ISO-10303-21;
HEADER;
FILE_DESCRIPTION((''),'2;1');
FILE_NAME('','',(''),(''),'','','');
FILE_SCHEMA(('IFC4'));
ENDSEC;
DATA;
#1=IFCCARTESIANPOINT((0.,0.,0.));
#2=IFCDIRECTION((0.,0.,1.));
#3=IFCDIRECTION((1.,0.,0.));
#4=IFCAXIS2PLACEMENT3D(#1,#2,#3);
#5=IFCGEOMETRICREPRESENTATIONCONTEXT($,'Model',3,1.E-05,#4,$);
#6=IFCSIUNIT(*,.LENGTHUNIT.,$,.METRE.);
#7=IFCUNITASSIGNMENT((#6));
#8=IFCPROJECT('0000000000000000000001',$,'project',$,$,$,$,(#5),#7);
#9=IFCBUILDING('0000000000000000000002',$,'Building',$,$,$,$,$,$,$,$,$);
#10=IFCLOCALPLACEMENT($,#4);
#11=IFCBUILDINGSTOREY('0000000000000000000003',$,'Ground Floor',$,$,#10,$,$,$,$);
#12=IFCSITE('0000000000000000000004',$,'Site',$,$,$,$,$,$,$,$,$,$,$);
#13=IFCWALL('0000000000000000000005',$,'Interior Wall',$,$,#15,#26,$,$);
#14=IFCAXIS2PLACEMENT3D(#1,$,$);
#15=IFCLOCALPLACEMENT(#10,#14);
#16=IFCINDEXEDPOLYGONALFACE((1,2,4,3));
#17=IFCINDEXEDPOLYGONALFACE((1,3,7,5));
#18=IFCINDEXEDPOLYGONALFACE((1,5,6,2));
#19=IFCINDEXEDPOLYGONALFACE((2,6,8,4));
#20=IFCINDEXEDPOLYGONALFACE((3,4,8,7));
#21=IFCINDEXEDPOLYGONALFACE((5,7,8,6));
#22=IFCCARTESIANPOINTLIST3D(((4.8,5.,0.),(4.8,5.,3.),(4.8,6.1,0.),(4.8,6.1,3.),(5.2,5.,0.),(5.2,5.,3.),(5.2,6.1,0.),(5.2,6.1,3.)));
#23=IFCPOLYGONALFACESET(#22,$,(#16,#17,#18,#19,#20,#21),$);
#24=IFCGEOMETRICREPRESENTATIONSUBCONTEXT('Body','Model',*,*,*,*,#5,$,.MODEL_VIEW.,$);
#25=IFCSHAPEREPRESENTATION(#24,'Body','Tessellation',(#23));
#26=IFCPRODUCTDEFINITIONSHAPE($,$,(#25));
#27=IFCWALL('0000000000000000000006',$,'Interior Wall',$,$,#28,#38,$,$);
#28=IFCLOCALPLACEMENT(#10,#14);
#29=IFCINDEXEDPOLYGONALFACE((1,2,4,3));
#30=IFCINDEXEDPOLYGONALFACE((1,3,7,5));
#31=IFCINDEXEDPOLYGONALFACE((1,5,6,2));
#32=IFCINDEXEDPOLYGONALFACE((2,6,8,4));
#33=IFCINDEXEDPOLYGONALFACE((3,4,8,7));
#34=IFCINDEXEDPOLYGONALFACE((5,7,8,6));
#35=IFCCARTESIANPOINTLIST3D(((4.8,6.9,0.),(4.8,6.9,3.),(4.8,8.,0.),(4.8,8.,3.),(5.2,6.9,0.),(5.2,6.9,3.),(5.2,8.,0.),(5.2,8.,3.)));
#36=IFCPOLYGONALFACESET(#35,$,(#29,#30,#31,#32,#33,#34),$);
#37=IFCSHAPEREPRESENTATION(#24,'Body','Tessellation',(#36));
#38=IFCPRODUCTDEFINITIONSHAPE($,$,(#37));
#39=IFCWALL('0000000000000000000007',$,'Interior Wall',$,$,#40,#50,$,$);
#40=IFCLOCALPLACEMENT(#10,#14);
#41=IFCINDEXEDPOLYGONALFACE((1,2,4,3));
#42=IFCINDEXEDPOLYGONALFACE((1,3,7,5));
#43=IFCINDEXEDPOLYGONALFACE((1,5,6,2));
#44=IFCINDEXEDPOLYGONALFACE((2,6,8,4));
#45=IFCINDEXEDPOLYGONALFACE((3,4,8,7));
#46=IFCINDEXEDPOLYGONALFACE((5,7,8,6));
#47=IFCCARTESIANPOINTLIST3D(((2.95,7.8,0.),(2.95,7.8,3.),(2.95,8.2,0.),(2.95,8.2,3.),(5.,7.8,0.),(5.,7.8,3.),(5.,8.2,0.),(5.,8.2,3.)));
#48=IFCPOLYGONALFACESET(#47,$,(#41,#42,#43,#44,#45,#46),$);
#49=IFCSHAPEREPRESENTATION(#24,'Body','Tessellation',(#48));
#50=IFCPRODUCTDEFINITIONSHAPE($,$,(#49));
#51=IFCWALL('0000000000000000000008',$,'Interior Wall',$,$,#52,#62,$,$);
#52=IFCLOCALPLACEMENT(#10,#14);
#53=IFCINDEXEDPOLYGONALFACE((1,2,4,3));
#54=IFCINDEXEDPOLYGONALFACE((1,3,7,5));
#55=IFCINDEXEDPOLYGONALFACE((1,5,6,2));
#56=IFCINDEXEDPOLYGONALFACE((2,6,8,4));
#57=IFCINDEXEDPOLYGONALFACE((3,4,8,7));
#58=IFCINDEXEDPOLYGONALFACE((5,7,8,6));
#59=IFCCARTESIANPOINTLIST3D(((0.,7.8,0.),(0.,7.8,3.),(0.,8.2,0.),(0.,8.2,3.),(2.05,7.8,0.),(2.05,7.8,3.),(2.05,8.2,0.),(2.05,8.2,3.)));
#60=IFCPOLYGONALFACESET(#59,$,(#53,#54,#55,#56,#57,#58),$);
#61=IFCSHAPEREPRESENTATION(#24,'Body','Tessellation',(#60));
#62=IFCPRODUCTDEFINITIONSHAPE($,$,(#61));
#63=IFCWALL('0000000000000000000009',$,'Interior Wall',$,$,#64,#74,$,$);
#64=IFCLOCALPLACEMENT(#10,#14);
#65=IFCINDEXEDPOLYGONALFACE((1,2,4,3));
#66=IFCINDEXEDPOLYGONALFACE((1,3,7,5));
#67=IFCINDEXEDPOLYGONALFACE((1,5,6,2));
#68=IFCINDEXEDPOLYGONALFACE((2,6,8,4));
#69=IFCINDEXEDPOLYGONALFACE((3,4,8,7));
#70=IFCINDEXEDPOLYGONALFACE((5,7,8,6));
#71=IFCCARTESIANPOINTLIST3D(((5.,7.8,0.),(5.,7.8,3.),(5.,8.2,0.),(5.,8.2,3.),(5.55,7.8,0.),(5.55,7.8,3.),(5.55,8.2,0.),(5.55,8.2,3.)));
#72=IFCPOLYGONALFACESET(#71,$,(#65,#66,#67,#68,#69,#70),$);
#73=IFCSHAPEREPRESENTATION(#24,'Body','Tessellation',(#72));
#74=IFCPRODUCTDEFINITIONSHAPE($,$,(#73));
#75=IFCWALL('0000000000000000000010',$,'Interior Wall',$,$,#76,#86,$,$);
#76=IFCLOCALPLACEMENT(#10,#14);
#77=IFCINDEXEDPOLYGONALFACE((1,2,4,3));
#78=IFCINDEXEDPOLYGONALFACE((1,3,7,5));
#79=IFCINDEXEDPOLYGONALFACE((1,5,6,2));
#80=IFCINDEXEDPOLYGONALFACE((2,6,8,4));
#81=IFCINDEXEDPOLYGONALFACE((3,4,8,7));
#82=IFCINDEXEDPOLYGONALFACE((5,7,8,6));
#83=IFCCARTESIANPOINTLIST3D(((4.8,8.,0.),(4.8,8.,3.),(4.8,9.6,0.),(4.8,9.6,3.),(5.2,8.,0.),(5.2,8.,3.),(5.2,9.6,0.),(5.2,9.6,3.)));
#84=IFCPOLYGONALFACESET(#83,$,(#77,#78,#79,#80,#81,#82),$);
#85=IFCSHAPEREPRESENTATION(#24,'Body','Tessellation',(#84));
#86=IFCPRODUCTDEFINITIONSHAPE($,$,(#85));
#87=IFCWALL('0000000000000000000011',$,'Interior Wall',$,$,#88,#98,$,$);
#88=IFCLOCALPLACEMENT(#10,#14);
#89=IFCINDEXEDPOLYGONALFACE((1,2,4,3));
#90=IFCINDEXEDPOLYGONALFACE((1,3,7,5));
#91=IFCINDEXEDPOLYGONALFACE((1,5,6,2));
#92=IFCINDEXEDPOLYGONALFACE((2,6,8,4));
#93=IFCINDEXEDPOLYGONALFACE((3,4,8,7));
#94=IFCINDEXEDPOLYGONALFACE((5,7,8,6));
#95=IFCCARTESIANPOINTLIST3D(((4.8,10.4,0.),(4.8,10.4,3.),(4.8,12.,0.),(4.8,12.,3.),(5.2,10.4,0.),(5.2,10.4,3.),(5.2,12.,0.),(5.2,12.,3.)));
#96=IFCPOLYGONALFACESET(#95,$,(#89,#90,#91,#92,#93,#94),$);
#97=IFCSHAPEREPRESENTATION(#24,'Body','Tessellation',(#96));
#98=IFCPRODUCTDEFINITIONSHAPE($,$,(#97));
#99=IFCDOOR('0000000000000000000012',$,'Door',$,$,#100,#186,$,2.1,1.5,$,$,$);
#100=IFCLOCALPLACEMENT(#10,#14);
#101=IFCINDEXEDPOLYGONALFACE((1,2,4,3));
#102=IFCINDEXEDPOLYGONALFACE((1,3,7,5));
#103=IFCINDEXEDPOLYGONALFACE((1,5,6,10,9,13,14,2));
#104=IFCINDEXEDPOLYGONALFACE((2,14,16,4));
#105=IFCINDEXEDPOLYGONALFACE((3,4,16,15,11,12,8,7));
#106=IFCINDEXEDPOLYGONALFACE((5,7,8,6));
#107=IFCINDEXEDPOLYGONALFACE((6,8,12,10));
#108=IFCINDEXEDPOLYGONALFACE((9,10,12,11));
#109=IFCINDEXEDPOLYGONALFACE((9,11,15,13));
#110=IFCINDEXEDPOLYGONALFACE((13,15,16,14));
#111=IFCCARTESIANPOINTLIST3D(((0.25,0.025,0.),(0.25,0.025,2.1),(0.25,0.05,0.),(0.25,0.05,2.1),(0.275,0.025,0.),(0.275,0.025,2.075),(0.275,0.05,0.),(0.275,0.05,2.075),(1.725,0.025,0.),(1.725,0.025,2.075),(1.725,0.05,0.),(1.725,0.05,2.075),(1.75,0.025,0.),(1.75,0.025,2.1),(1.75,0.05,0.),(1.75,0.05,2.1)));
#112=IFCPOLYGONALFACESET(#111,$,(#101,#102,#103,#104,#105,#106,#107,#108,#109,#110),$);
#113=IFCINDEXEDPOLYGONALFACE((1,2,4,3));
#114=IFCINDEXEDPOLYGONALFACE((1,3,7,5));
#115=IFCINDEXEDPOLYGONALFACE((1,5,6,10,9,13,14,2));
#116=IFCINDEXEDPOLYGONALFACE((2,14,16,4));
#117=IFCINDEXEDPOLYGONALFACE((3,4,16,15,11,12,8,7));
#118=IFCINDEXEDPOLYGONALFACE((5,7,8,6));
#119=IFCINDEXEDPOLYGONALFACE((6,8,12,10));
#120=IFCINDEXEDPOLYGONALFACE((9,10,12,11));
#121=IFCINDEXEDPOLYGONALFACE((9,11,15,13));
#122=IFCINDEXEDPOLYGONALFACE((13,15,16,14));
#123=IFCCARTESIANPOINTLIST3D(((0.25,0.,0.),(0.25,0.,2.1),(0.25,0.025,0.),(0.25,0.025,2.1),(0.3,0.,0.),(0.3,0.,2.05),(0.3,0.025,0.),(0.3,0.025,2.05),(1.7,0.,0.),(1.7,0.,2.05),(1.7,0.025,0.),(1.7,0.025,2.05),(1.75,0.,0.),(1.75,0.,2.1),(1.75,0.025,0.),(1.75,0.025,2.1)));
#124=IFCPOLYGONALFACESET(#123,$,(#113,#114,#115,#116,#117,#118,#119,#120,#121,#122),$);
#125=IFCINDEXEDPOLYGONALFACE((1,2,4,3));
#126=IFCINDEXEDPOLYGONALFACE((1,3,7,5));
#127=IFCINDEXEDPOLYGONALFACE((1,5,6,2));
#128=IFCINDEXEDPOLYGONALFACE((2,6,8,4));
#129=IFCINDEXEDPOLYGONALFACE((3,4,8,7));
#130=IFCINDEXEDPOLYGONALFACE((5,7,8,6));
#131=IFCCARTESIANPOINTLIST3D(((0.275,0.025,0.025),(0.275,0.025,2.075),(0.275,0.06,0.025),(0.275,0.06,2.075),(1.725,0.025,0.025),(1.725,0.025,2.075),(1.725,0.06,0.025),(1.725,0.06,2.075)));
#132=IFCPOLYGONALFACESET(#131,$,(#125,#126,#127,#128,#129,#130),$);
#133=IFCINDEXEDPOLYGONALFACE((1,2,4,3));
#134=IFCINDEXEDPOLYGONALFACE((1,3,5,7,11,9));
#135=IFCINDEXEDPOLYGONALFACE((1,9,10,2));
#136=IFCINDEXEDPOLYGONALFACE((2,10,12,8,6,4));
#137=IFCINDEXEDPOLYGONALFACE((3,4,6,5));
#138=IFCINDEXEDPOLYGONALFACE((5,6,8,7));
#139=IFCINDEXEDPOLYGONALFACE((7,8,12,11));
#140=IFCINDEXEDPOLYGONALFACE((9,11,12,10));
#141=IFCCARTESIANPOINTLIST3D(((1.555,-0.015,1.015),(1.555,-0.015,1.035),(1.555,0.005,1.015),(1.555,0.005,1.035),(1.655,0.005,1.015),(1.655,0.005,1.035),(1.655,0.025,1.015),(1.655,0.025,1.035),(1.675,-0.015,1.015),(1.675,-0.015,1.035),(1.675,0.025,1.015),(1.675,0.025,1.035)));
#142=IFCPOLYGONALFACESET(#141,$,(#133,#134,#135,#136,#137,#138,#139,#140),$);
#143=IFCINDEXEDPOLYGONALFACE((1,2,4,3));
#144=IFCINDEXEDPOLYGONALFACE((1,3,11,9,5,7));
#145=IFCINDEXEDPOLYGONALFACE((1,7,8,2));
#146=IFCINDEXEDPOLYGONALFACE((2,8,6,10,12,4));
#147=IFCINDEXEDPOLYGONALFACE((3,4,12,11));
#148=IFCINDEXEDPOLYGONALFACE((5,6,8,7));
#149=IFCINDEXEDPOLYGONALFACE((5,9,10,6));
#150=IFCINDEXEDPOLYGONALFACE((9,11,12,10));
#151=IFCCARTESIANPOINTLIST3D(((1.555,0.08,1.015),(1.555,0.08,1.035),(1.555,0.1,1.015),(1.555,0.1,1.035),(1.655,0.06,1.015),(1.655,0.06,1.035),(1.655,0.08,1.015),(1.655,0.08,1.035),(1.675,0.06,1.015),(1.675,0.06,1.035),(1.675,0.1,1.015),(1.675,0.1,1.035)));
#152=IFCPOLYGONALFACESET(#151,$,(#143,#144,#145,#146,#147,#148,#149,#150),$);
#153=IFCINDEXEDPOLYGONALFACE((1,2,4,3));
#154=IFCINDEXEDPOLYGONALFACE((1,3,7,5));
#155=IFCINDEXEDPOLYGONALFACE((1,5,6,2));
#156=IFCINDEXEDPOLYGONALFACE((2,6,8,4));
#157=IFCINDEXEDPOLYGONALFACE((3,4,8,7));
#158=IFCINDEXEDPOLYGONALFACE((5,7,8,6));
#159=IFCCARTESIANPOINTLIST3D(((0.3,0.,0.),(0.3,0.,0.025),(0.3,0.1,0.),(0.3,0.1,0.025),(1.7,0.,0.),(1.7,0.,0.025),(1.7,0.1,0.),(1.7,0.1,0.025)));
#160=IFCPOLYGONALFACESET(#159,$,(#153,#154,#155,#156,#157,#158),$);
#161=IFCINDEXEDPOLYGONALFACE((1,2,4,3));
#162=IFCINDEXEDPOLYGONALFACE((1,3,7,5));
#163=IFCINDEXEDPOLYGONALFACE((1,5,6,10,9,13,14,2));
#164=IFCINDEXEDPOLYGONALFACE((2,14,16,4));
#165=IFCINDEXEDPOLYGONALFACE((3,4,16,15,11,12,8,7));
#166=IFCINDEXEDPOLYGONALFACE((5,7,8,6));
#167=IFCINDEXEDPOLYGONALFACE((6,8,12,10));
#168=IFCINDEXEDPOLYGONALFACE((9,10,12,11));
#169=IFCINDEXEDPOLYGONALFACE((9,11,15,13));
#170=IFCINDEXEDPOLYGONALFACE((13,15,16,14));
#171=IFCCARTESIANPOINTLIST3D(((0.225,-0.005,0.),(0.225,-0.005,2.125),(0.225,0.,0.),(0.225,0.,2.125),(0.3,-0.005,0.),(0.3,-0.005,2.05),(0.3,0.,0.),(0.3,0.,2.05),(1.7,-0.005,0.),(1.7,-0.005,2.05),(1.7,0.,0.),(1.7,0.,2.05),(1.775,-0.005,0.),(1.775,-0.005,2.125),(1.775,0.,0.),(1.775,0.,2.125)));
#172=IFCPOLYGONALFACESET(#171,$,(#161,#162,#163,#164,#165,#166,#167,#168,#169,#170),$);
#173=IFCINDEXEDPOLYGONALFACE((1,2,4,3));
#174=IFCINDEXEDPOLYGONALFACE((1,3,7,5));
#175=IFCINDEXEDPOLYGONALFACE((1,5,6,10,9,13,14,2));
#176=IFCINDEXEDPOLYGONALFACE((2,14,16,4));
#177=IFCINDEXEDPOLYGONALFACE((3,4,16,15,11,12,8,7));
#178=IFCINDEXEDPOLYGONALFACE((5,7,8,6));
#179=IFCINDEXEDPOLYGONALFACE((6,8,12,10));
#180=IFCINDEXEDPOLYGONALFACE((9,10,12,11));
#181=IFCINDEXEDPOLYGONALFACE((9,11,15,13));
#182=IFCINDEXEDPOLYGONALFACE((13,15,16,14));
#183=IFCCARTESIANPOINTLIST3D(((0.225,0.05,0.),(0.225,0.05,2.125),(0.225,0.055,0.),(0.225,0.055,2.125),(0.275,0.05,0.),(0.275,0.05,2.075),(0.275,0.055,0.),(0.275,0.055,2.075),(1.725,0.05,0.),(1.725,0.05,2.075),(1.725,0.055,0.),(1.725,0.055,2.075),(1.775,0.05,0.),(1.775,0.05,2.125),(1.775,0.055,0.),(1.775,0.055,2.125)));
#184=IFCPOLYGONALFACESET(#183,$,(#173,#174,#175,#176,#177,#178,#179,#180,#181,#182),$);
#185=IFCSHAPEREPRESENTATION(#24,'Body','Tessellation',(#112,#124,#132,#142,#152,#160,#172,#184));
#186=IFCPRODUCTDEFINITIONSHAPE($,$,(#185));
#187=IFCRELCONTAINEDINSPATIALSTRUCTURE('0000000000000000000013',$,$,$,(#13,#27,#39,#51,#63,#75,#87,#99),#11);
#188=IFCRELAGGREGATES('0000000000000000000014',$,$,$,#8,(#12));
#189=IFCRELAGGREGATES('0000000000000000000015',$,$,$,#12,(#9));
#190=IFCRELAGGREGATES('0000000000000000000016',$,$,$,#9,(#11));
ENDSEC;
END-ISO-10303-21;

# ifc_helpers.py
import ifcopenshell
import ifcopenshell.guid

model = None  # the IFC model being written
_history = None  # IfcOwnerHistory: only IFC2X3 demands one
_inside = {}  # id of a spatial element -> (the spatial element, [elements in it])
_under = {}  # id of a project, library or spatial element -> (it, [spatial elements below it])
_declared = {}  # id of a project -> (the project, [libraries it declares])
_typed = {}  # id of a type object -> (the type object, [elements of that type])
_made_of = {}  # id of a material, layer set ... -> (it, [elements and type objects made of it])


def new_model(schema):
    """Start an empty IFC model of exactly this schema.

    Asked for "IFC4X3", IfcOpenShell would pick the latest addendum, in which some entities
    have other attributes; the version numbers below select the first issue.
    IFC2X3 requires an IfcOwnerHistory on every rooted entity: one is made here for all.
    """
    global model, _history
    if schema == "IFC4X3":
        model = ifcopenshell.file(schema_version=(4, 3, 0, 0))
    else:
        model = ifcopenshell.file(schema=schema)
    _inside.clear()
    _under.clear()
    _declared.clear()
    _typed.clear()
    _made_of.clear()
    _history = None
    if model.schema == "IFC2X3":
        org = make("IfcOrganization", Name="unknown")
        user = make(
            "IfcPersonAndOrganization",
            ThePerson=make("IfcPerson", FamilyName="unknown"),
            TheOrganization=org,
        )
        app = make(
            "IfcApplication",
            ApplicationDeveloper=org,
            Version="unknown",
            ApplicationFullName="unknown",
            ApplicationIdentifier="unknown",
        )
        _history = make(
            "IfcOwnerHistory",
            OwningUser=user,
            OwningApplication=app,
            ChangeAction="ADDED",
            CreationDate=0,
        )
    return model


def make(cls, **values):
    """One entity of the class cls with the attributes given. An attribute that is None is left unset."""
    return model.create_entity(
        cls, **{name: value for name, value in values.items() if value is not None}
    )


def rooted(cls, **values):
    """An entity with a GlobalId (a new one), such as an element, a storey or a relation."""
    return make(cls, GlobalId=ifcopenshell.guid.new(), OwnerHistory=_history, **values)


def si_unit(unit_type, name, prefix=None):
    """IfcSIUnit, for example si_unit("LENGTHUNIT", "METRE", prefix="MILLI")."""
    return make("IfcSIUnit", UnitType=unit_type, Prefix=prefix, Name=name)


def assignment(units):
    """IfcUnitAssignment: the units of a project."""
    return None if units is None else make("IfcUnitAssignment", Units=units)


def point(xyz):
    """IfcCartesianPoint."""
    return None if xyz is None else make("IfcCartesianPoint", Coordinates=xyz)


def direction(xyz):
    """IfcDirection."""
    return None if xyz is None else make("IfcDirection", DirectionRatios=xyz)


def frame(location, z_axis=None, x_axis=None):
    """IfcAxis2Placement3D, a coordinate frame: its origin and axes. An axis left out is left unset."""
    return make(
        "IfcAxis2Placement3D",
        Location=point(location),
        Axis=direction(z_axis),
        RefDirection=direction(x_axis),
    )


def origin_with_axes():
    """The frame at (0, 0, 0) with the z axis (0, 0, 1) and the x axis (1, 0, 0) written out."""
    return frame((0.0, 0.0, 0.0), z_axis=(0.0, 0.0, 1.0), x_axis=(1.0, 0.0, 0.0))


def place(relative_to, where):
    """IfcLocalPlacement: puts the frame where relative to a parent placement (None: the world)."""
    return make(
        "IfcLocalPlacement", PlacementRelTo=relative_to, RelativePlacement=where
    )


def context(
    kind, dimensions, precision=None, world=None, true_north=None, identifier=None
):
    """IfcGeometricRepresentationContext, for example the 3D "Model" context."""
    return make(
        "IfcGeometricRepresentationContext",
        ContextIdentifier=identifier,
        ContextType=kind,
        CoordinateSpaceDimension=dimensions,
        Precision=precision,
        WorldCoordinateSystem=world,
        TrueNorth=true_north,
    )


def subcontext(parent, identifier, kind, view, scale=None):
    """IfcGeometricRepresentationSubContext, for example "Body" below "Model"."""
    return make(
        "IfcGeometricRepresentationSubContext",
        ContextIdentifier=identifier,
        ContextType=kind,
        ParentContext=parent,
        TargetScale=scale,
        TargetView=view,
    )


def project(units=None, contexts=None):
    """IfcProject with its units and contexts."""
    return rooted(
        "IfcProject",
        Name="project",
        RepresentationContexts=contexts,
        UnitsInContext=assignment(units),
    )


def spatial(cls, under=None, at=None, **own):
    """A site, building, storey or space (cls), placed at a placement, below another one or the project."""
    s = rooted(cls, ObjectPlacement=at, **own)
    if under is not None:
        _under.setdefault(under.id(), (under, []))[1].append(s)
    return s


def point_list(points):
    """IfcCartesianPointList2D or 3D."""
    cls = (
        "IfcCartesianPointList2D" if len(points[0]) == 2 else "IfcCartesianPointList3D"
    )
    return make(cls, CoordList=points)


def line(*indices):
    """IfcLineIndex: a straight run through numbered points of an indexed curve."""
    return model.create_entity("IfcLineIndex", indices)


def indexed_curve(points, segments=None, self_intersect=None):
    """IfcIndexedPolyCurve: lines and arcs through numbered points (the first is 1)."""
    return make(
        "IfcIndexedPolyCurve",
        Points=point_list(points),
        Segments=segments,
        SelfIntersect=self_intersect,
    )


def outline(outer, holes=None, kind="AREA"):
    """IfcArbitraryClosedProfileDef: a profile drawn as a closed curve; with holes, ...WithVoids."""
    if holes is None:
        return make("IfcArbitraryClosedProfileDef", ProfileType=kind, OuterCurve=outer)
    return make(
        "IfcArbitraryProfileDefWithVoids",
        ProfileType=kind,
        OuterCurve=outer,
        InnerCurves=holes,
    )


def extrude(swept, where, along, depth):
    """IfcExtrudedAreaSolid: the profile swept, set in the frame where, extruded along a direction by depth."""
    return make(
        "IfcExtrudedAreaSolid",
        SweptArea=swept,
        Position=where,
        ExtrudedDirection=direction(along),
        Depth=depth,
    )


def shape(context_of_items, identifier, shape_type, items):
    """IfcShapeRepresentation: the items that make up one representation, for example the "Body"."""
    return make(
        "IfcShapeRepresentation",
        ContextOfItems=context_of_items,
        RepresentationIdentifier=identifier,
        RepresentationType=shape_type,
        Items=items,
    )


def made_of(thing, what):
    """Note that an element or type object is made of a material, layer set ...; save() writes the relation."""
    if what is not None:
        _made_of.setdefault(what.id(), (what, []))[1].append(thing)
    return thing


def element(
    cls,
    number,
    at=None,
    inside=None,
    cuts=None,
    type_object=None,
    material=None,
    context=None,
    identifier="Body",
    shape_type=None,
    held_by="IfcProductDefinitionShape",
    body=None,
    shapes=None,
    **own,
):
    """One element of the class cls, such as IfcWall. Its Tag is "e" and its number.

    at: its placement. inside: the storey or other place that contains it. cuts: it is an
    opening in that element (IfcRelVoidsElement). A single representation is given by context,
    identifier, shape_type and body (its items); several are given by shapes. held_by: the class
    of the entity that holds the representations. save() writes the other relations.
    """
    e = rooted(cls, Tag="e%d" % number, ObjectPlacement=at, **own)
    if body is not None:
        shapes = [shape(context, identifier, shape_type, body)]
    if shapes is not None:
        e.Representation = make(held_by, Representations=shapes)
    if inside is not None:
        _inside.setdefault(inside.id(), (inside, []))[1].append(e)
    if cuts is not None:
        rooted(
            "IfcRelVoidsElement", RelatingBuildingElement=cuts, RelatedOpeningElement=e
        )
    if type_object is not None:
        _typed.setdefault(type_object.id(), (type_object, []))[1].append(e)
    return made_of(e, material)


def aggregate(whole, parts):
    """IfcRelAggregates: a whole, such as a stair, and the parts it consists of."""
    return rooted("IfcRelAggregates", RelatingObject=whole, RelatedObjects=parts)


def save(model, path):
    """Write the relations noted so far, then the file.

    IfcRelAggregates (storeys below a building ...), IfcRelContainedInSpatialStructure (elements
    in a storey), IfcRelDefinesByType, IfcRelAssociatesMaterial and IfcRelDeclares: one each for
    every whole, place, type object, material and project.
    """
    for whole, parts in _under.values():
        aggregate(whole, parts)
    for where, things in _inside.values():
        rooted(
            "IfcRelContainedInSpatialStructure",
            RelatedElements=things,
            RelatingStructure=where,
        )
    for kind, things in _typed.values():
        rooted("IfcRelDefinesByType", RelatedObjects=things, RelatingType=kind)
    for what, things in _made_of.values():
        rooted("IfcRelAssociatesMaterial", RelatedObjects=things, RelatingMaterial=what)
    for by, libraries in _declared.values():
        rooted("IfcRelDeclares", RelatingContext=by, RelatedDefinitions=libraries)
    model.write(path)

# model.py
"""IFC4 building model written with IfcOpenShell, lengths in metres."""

from ifc_helpers import new_model, si_unit, frame, origin_with_axes, place, context, subcontext, project, spatial, line, indexed_curve, outline, extrude, element, save


model = new_model("IFC4")

# Units and contexts
model_context = context("Model", 3, precision=1e-05, world=origin_with_axes())
body_context = subcontext(model_context, "Body", "Model", "MODEL_VIEW")
ifc_project = project(units=[si_unit("LENGTHUNIT", "METRE")], contexts=[model_context])

# Site, building, storey
site = spatial("IfcSite", under=ifc_project, Name="Site")
building = spatial("IfcBuilding", under=site, Name="Building")
storey_placement = place(None, origin_with_axes())
storey = spatial("IfcBuildingStorey", under=building, at=storey_placement, Name="Ground Floor")

# Walls
for number, where, z_axis, x_axis, name in (
    (1, (5.0, 5.0, 0.0), (0.0, 0.0, 1.0), (0.0, 1.0, 0.0), "Interior Wall"),
    (2, (5.0, 6.9, 0.0), (0.0, 0.0, 1.0), (0.0, 1.0, 0.0), "Interior Wall"),
):
    element("IfcWall", number, at=place(storey_placement, frame(where, z_axis=z_axis, x_axis=x_axis)), inside=storey, Name=name, context=body_context, shape_type="SweptSolid", body=[
        extrude(outline(indexed_curve([(0.0, 0.0), (0.0, 0.4), (1.1, 0.4), (1.1, 0.0), (0.0, 0.0)], self_intersect=False)), frame((0.0, -0.2, 0.0), z_axis=(0.0, 0.0, 1.0), x_axis=(1.0, 0.0, 0.0)), (0.0, 0.0, 1.0), 3.0),
    ])
for number, where, z_axis, x_axis, name in (
    (3, (5.0, 8.0, 0.0), (0.0, 0.0, 1.0), (-1.0, 0.0, 0.0), "Interior Wall"),
    (4, (2.05, 8.0, 0.0), (0.0, 0.0, 1.0), (-1.0, 0.0, 0.0), "Interior Wall"),
):
    element("IfcWall", number, at=place(storey_placement, frame(where, z_axis=z_axis, x_axis=x_axis)), inside=storey, Name=name, context=body_context, shape_type="SweptSolid", body=[
        extrude(outline(indexed_curve([(0.0, 0.0), (0.0, 0.4), (2.05, 0.4), (2.05, 0.0), (0.0, 0.0)], self_intersect=False)), frame((0.0, -0.2, 0.0), z_axis=(0.0, 0.0, 1.0), x_axis=(1.0, 0.0, 0.0)), (0.0, 0.0, 1.0), 3.0),
    ])
wall_1_placement = place(storey_placement, frame((5.55, 8.0, 0.0), z_axis=(0.0, 0.0, 1.0), x_axis=(-1.0, 0.0, 0.0)))
element("IfcWall", 5, at=wall_1_placement, inside=storey, Name="Interior Wall", context=body_context, shape_type="SweptSolid", body=[
    extrude(outline(indexed_curve([(0.0, 0.0), (0.0, 0.4), (0.55, 0.4), (0.55, 0.0), (0.0, 0.0)], self_intersect=False)), frame((0.0, -0.2, 0.0), z_axis=(0.0, 0.0, 1.0), x_axis=(1.0, 0.0, 0.0)), (0.0, 0.0, 1.0), 3.0),
])
for number, where, z_axis, x_axis, name in (
    (6, (5.0, 8.0, 0.0), (0.0, 0.0, 1.0), (0.0, 1.0, 0.0), "Interior Wall"),
    (7, (5.0, 10.4, 0.0), (0.0, 0.0, 1.0), (0.0, 1.0, 0.0), "Interior Wall"),
):
    element("IfcWall", number, at=place(storey_placement, frame(where, z_axis=z_axis, x_axis=x_axis)), inside=storey, Name=name, context=body_context, shape_type="SweptSolid", body=[
        extrude(outline(indexed_curve([(0.0, 0.0), (0.0, 0.4), (1.6, 0.4), (1.6, 0.0), (0.0, 0.0)], self_intersect=False)), frame((0.0, -0.2, 0.0), z_axis=(0.0, 0.0, 1.0), x_axis=(1.0, 0.0, 0.0)), (0.0, 0.0, 1.0), 3.0),
    ])

# Door
door_1_placement = place(storey_placement, frame((0.25, 0.0, 0.0), z_axis=(0.0, 0.0, 1.0), x_axis=(1.0, 0.0, 0.0)))
element("IfcDoor", 8, at=door_1_placement, inside=storey, Name="Door", OverallHeight=2.1, OverallWidth=1.5, context=body_context, shape_type="SweptSolid", body=[
    extrude(outline(indexed_curve([(0.0, 0.0), (0.0, 2.1), (1.5, 2.1), (1.5, 0.0), (1.475, 0.0), (1.475, 2.075), (0.025, 2.075), (0.025, 0.0)], segments=[line(1, 2, 3, 4, 5, 6, 7, 8, 1)])), frame((0.0, 0.025, 0.0), z_axis=(0.0, -1.0, 0.0), x_axis=(1.0, 0.0, 0.0)), (0.0, 0.0, -1.0), 0.025),
    extrude(outline(indexed_curve([(0.0, 0.0), (0.0, 2.1), (1.5, 2.1), (1.5, 0.0), (1.45, 0.0), (1.45, 2.05), (0.05, 2.05), (0.05, 0.0)], segments=[line(1, 2, 3, 4, 5, 6, 7, 8, 1)])), frame((0.0, 0.0, 0.0), z_axis=(0.0, -1.0, 0.0), x_axis=(1.0, 0.0, 0.0)), (0.0, 0.0, -1.0), 0.025),
    extrude(outline(indexed_curve([(0.0, 0.0), (1.45, 0.0), (1.45, 0.035), (0.0, 0.035)], segments=[line(1, 2, 3, 4, 1)])), frame((0.025, 0.025, 0.025), z_axis=(0.0, 0.0, 1.0), x_axis=(1.0, 0.0, 0.0)), (0.0, 0.0, 1.0), 2.05),
    extrude(outline(indexed_curve([(0.0, 0.0), (0.0, -0.04), (-0.12, -0.04), (-0.12, -0.02), (-0.02, -0.02), (-0.02, 0.0)], segments=[line(1, 2, 3, 4, 5, 6, 1)])), frame((1.425, 0.025, 1.015), z_axis=(0.0, 0.0, 1.0), x_axis=(1.0, 0.0, 0.0)), (0.0, 0.0, 1.0), 0.02),
    extrude(outline(indexed_curve([(0.0, 0.0), (0.0, 0.04), (-0.12, 0.04), (-0.12, 0.02), (-0.02, 0.02), (-0.02, 0.0)], segments=[line(1, 2, 3, 4, 5, 6, 1)])), frame((1.425, 0.06, 1.015), z_axis=(0.0, 0.0, 1.0), x_axis=(1.0, 0.0, 0.0)), (0.0, 0.0, 1.0), 0.02),
    extrude(outline(indexed_curve([(0.0, 0.0), (1.4, 0.0), (1.4, 0.1), (0.0, 0.1)], segments=[line(1, 2, 3, 4, 1)])), frame((0.05, 0.0, 0.0), z_axis=(0.0, 0.0, 1.0), x_axis=(1.0, 0.0, 0.0)), (0.0, 0.0, 1.0), 0.025),
    extrude(outline(indexed_curve([(0.0, 0.0), (0.0, 2.125), (1.55, 2.125), (1.55, 0.0), (1.475, 0.0), (1.475, 2.05), (0.075, 2.05), (0.075, 0.0)], segments=[line(1, 2, 3, 4, 5, 6, 7, 8, 1)])), frame((-0.025, -0.005, 0.0), z_axis=(0.0, -1.0, 0.0), x_axis=(1.0, 0.0, 0.0)), (0.0, 0.0, -1.0), 0.005),
    extrude(outline(indexed_curve([(0.0, 0.0), (0.0, 2.125), (1.55, 2.125), (1.55, 0.0), (1.5, 0.0), (1.5, 2.075), (0.05, 2.075), (0.05, 0.0)], segments=[line(1, 2, 3, 4, 5, 6, 7, 8, 1)])), frame((-0.025, 0.05, 0.0), z_axis=(0.0, -1.0, 0.0), x_axis=(1.0, 0.0, 0.0)), (0.0, 0.0, -1.0), 0.005),
])

save(model, "model.ifc")
